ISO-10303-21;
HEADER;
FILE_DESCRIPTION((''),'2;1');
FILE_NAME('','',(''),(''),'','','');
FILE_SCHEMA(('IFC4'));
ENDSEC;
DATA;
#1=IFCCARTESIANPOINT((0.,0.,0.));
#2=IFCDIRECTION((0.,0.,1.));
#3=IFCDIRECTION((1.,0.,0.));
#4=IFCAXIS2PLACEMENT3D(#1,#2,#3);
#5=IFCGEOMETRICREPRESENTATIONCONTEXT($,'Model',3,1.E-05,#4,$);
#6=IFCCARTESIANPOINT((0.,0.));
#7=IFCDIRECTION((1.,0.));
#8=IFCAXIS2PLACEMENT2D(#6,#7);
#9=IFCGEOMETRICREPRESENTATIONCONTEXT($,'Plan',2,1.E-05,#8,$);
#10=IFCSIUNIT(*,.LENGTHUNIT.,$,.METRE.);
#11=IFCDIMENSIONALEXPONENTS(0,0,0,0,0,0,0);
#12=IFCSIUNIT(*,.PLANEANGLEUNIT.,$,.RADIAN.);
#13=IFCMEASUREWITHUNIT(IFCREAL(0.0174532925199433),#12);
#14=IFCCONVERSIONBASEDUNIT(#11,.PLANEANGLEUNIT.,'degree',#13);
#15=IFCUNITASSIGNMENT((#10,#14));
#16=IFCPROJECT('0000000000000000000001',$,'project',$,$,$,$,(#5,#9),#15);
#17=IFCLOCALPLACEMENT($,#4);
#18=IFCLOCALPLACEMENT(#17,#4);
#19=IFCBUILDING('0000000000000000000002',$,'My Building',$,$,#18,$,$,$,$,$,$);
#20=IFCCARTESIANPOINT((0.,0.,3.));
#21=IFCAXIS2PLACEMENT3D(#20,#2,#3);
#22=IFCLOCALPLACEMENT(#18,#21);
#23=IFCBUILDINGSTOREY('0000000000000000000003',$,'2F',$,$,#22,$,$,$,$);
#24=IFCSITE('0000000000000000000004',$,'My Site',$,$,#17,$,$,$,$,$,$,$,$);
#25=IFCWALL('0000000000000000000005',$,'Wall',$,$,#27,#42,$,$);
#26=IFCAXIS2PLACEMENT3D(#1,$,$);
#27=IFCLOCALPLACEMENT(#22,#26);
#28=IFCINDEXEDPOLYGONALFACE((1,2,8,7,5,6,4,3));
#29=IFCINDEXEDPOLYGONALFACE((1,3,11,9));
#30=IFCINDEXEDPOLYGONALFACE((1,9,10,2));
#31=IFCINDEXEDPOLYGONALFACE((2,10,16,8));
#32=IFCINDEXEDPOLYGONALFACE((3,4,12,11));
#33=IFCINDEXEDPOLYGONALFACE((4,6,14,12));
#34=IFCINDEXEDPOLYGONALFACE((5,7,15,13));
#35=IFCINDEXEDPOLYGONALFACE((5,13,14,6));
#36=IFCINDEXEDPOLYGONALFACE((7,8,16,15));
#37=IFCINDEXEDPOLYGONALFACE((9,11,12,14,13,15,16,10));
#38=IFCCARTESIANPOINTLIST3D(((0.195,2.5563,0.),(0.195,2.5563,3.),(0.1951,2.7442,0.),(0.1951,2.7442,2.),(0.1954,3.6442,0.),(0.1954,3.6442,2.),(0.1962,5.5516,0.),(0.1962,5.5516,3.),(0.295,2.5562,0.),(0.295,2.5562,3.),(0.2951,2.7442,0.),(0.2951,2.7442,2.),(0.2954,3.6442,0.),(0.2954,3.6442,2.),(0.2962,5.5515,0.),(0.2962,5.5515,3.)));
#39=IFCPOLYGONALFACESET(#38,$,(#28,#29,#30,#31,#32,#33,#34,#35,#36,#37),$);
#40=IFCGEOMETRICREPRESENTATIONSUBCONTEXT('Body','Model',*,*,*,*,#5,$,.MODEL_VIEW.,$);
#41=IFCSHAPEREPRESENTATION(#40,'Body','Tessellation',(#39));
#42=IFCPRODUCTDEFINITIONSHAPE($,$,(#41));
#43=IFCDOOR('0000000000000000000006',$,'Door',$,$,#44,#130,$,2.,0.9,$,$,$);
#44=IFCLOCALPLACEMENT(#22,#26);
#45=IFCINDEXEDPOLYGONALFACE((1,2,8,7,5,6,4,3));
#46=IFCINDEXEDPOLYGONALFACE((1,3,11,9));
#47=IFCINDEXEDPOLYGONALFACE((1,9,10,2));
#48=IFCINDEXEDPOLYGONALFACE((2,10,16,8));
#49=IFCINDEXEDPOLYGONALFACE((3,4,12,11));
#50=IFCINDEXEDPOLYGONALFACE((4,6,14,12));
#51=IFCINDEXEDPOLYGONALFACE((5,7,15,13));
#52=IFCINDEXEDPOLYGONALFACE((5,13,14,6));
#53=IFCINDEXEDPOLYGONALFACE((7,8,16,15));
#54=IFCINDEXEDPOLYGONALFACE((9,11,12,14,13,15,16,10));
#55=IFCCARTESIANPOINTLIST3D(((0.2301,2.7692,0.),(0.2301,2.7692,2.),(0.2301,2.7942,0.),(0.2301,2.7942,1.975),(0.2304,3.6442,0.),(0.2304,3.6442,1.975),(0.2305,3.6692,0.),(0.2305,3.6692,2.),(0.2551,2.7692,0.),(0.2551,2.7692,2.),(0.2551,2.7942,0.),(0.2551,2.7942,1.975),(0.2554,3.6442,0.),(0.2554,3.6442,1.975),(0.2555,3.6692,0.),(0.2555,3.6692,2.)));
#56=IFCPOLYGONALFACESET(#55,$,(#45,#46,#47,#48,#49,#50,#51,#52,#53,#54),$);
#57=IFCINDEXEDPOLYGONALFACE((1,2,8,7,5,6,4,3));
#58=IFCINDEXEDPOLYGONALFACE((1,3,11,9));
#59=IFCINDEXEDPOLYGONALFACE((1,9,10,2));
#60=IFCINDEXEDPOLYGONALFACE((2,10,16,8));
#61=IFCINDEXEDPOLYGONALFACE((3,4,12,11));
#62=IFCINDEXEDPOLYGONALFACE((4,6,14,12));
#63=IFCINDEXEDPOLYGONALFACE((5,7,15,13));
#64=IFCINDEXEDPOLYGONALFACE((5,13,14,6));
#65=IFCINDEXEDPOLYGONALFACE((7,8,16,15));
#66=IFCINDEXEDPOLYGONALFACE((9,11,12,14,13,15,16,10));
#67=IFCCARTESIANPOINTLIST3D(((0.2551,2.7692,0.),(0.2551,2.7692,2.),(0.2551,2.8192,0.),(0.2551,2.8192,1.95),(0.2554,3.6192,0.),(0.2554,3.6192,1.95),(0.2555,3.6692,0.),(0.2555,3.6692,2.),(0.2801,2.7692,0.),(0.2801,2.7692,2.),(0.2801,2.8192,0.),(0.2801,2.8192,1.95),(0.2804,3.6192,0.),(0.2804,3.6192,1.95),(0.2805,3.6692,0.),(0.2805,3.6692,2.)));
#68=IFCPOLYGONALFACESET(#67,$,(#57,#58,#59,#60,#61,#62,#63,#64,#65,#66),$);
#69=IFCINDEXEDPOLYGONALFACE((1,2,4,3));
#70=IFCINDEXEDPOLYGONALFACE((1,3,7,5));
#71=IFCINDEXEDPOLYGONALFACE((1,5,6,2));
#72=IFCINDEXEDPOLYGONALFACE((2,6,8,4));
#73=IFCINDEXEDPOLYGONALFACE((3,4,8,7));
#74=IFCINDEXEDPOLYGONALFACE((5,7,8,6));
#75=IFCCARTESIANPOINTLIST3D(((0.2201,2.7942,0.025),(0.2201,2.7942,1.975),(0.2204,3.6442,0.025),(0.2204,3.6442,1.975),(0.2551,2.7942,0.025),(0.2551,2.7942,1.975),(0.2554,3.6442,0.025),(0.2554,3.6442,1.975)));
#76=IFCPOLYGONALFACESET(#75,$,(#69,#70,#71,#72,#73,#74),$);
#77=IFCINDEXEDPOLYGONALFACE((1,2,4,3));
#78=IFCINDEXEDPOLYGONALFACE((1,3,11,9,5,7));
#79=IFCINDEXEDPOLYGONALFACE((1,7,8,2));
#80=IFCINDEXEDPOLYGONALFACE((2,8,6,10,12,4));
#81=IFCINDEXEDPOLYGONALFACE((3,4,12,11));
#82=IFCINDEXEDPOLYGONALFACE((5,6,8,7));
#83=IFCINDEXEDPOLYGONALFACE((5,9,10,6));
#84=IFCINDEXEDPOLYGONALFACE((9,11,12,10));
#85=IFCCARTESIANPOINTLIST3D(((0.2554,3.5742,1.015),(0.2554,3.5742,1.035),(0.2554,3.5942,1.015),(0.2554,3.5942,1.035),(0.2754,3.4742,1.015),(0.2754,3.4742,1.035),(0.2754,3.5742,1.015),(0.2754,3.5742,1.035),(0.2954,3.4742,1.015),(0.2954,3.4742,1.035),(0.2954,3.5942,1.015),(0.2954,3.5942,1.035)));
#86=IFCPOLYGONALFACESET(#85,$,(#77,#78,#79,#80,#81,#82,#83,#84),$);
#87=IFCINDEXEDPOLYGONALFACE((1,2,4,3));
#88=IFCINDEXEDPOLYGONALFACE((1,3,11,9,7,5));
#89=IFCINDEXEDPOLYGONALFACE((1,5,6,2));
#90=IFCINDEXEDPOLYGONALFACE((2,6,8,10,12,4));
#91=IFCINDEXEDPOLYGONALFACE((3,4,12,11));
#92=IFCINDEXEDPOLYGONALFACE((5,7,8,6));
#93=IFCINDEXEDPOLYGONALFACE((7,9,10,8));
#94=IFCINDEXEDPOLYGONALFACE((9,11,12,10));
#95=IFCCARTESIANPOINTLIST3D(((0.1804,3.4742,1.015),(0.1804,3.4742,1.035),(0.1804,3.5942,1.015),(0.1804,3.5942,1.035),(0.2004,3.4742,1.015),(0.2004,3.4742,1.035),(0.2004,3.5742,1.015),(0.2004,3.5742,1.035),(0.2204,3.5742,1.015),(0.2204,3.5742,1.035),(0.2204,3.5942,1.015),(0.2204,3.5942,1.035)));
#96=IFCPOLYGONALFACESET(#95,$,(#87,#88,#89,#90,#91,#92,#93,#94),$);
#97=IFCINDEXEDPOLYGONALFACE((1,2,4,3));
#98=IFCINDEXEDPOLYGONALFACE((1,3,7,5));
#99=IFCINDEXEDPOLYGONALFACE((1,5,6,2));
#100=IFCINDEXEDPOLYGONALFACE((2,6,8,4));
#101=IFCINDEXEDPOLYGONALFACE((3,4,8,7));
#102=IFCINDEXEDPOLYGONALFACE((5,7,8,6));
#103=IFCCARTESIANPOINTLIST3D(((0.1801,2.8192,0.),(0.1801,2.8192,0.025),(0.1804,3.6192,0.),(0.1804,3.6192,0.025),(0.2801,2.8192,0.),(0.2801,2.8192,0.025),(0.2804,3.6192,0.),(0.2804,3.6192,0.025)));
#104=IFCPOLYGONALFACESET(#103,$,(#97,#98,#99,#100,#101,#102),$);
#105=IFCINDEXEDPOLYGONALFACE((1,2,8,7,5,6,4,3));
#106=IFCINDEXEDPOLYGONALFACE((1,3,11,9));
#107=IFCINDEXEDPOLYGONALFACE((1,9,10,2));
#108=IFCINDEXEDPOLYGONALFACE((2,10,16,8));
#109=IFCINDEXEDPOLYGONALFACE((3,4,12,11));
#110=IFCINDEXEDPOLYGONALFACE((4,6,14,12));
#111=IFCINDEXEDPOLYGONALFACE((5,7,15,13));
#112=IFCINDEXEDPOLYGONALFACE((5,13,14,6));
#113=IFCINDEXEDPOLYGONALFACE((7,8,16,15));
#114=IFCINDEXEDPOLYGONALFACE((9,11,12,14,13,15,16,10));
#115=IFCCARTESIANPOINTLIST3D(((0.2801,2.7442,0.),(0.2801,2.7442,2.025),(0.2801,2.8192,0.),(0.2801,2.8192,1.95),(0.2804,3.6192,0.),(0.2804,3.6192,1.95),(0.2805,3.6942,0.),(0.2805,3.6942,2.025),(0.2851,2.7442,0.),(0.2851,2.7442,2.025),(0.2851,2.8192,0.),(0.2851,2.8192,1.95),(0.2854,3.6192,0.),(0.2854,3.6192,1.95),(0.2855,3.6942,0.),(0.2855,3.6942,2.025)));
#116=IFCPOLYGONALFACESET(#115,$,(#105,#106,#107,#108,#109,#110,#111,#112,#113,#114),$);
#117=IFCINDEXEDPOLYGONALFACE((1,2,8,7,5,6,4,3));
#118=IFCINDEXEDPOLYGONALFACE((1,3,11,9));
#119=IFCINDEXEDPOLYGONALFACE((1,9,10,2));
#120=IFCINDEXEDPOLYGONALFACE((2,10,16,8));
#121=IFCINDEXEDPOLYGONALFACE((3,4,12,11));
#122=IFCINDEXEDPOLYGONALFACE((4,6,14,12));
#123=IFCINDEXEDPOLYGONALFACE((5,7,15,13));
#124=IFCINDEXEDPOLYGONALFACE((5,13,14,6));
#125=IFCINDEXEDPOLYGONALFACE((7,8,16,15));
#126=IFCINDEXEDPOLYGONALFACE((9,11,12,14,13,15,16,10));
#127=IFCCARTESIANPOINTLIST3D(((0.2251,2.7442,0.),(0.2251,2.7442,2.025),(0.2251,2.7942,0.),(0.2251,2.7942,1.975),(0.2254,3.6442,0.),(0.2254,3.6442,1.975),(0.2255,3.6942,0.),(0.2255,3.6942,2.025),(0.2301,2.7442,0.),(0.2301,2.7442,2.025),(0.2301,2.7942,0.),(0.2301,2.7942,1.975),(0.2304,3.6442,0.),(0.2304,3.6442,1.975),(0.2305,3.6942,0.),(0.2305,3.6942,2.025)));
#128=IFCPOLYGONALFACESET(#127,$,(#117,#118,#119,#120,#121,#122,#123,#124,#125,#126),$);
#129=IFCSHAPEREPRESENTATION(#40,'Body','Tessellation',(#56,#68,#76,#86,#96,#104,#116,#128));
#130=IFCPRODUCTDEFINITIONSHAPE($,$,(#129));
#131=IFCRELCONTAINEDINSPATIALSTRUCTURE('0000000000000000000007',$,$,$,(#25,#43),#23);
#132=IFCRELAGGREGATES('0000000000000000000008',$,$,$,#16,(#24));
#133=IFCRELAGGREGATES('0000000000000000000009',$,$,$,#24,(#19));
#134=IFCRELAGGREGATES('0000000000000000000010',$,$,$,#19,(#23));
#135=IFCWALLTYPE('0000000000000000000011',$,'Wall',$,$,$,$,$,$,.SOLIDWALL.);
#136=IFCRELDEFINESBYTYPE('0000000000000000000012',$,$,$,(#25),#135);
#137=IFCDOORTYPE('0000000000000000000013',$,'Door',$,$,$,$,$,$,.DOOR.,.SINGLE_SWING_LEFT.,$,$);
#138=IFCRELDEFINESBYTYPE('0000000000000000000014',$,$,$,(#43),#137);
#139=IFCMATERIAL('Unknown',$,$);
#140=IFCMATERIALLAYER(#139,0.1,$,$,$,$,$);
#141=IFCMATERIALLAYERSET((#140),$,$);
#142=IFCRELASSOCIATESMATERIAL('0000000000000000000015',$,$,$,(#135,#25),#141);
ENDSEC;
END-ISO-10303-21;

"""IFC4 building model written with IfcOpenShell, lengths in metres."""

from ifc_helpers import new_model, entity, si_unit, converted_unit, frame, origin_with_axes, origin_2d_with_axis, place, context, subcontext, project, spatial, line, indexed_curve, outline, extrude, shape, source, transform, mapped, material, layer, layer_set, layer_usage, type_object, type_shapes, element, fill, save


model = new_model("IFC4")

# Units and contexts
model_context = context("Model", 3, precision=1e-05, world=origin_with_axes())
plan_context = context("Plan", 2, precision=1e-05, world=origin_2d_with_axis())
body_context_1 = subcontext(model_context, "Body", "Model", "MODEL_VIEW")
body_context_2 = subcontext(plan_context, "Body", "Plan", "PLAN_VIEW")
ifc_project = project(units=[si_unit("LENGTHUNIT", "METRE"), converted_unit("PLANEANGLEUNIT", "degree", entity("IfcReal", 0.0174532925199433), si_unit("PLANEANGLEUNIT", "RADIAN"), dimensions=[0, 0, 0, 0, 0, 0, 0])], contexts=[model_context, plan_context])

# Site, building, storey
site_placement = place(None, origin_with_axes())
site = spatial("IfcSite", under=ifc_project, at=site_placement, Name="My Site")
building_placement = place(site_placement, origin_with_axes())
building = spatial("IfcBuilding", under=site, at=building_placement, Name="My Building")
storey_placement = place(building_placement, frame((0.0, 0.0, 3.0), z_axis=(0.0, 0.0, 1.0), x_axis=(1.0, 0.0, 0.0)))
storey = spatial("IfcBuildingStorey", under=building, at=storey_placement, Name="2F")

# Shared definitions
ifc_material = material(Name="Unknown")

# Shared definitions
ifc_layer = layer(ifc_material, 0.1)
ifc_layer_set = layer_set([ifc_layer])
wall_type = type_object("IfcWallType", Name="Wall", PredefinedType="SOLIDWALL", material=ifc_layer_set)

# Wall, opening, door
ifc_layer_usage_1 = layer_usage(ifc_layer_set, "AXIS2", "POSITIVE", 0.0)
wall_1_placement = place(storey_placement, frame((0.1962, 5.5516, 0.0), z_axis=(0.0, 0.0, 1.0), x_axis=(-0.000399, -1.0, 0.0)))
wall_1 = element("IfcWall", 1, at=wall_1_placement, inside=storey, type_object=wall_type, material=ifc_layer_usage_1, Name="Wall", context=body_context_1, shape_type="SweptSolid", body=[
    extrude(outline(indexed_curve([(0.0, 0.0), (0.0, 0.1), (2.9953, 0.1), (2.9953, 0.0)], segments=[line(1, 2, 3, 4, 1)])), origin_with_axes(), (0.0, 0.0, 1.0), 3.0),
])
shared_shape_1 = source(origin_with_axes(), body_context_1, "Body", "SweptSolid", [
    extrude(outline(indexed_curve([(0.0, 0.0), (0.9, 0.0), (0.9, 2.0), (0.0, 2.0)], segments=[line(1, 2, 3, 4, 1)])), frame((0.0, -0.6, 0.0), z_axis=(0.0, -1.0, 0.0), x_axis=(1.0, 0.0, 0.0)), (0.0, 0.0, -1.0), 1.2),
])
opening_1_placement = place(wall_1_placement, frame((1.9074, 0.0, 0.0), z_axis=(0.0, 0.0, 1.0), x_axis=(1.0, 0.0, 0.0)))
opening_1 = element("IfcOpeningElement", 2, at=opening_1_placement, cuts=wall_1, PredefinedType="OPENING", context=body_context_1, shape_type="MappedRepresentation", body=[
    mapped(shared_shape_1, transform((0.0, 0.0, 0.0), x_axis=(1.0, 0.0, 0.0), y_axis=(0.0, 1.0, 0.0), z_axis=(0.0, 0.0, 1.0), scale=1.0)),
])
door_type = type_object("IfcDoorType", Name="Door", OperationType="SINGLE_SWING_LEFT", PredefinedType="DOOR")
shared_shape_2 = source(origin_with_axes(), body_context_1, "Body", "SweptSolid", [
    extrude(outline(indexed_curve([(0.0, 0.0), (0.0, 2.0), (0.9, 2.0), (0.9, 0.0), (0.875, 0.0), (0.875, 1.975), (0.025, 1.975), (0.025, 0.0)], segments=[line(1, 2, 3, 4, 5, 6, 7, 8, 1)])), frame((0.0, 0.025, 0.0), z_axis=(0.0, -1.0, 0.0), x_axis=(1.0, 0.0, 0.0)), (0.0, 0.0, -1.0), 0.025),
    extrude(outline(indexed_curve([(0.0, 0.0), (0.0, 2.0), (0.9, 2.0), (0.9, 0.0), (0.85, 0.0), (0.85, 1.95), (0.05, 1.95), (0.05, 0.0)], segments=[line(1, 2, 3, 4, 5, 6, 7, 8, 1)])), frame((0.0, 0.0, 0.0), z_axis=(0.0, -1.0, 0.0), x_axis=(1.0, 0.0, 0.0)), (0.0, 0.0, -1.0), 0.025),
    extrude(outline(indexed_curve([(0.0, 0.0), (0.85, 0.0), (0.85, 0.035), (0.0, 0.035)], segments=[line(1, 2, 3, 4, 1)])), frame((0.025, 0.025, 0.025), z_axis=(0.0, 0.0, 1.0), x_axis=(1.0, 0.0, 0.0)), (0.0, 0.0, 1.0), 1.95),
    extrude(outline(indexed_curve([(0.0, 0.0), (0.0, -0.04), (-0.12, -0.04), (-0.12, -0.02), (-0.02, -0.02), (-0.02, 0.0)], segments=[line(1, 2, 3, 4, 5, 6, 1)])), frame((0.825, 0.025, 1.015), z_axis=(0.0, 0.0, 1.0), x_axis=(1.0, 0.0, 0.0)), (0.0, 0.0, 1.0), 0.02),
    extrude(outline(indexed_curve([(0.0, 0.0), (0.0, 0.04), (-0.12, 0.04), (-0.12, 0.02), (-0.02, 0.02), (-0.02, 0.0)], segments=[line(1, 2, 3, 4, 5, 6, 1)])), frame((0.825, 0.06, 1.015), z_axis=(0.0, 0.0, 1.0), x_axis=(1.0, 0.0, 0.0)), (0.0, 0.0, 1.0), 0.02),
    extrude(outline(indexed_curve([(0.0, 0.0), (0.8, 0.0), (0.8, 0.1), (0.0, 0.1)], segments=[line(1, 2, 3, 4, 1)])), frame((0.05, 0.0, 0.0), z_axis=(0.0, 0.0, 1.0), x_axis=(1.0, 0.0, 0.0)), (0.0, 0.0, 1.0), 0.025),
    extrude(outline(indexed_curve([(0.0, 0.0), (0.0, 2.025), (0.95, 2.025), (0.95, 0.0), (0.875, 0.0), (0.875, 1.95), (0.075, 1.95), (0.075, 0.0)], segments=[line(1, 2, 3, 4, 5, 6, 7, 8, 1)])), frame((-0.025, -0.005, 0.0), z_axis=(0.0, -1.0, 0.0), x_axis=(1.0, 0.0, 0.0)), (0.0, 0.0, -1.0), 0.005),
    extrude(outline(indexed_curve([(0.0, 0.0), (0.0, 2.025), (0.95, 2.025), (0.95, 0.0), (0.9, 0.0), (0.9, 1.975), (0.05, 1.975), (0.05, 0.0)], segments=[line(1, 2, 3, 4, 5, 6, 7, 8, 1)])), frame((-0.025, 0.05, 0.0), z_axis=(0.0, -1.0, 0.0), x_axis=(1.0, 0.0, 0.0)), (0.0, 0.0, -1.0), 0.005),
])
shared_shape_3 = source(origin_with_axes(), body_context_2, "Body", "Curve2D", [
    entity("IfcIndexedPolyCurve", entity("IfcCartesianPointList2D", [[0.0, 0.0], [0.0, 0.05], [0.025, 0.05], [0.025, 0.025], [0.05, 0.025], [0.05, 0.0]]), [entity("IfcLineIndex", [1, 2, 3, 4, 5, 6, 1])]),
    entity("IfcIndexedPolyCurve", entity("IfcCartesianPointList2D", [[0.9, 0.0], [0.9, 0.05], [0.875, 0.05], [0.875, 0.025], [0.85, 0.025], [0.85, 0.0]]), [entity("IfcLineIndex", [1, 2, 3, 4, 5, 6, 1])]),
    entity("IfcTrimmedCurve", entity("IfcEllipse", entity("IfcAxis2Placement2D", entity("IfcCartesianPoint", [0.06, 0.05]), entity("IfcDirection", [1.0, 0.0])), 0.815, 0.85), [entity("IfcCartesianPoint", [0.875, 0.05])], [entity("IfcCartesianPoint", [0.06, 0.9])], True, "CARTESIAN"),
    entity("IfcIndexedPolyCurve", entity("IfcCartesianPointList2D", [[0.025, 0.05], [0.06, 0.05], [0.06, 0.9], [0.025, 0.9]]), [entity("IfcLineIndex", [1, 2, 3, 4, 1])]),
])
type_shapes(door_type, [shared_shape_2, shared_shape_3])
door_1_placement = place(opening_1_placement, frame((0.875, 0.085, 0.0), z_axis=(0.0, 0.0, 1.0), x_axis=(-1.0, 0.0, 0.0)))
door_1 = element("IfcDoor", 3, at=door_1_placement, inside=storey, type_object=door_type, Name="Door", OverallHeight=2.0, OverallWidth=0.9, shapes=[
    shape(body_context_1, "Body", "MappedRepresentation", [mapped(shared_shape_2, transform((0.0, 0.0, 0.0), x_axis=(1.0, 0.0, 0.0), y_axis=(0.0, 1.0, 0.0), z_axis=(0.0, 0.0, 1.0), scale=1.0))]),
    shape(body_context_2, "Body", "MappedRepresentation", [mapped(shared_shape_3, transform((0.0, 0.0, 0.0), x_axis=(1.0, 0.0, 0.0), y_axis=(0.0, 1.0, 0.0), z_axis=(0.0, 0.0, 1.0), scale=1.0))]),
])
fill(opening_1, door_1)

save(model, "model.ifc")
